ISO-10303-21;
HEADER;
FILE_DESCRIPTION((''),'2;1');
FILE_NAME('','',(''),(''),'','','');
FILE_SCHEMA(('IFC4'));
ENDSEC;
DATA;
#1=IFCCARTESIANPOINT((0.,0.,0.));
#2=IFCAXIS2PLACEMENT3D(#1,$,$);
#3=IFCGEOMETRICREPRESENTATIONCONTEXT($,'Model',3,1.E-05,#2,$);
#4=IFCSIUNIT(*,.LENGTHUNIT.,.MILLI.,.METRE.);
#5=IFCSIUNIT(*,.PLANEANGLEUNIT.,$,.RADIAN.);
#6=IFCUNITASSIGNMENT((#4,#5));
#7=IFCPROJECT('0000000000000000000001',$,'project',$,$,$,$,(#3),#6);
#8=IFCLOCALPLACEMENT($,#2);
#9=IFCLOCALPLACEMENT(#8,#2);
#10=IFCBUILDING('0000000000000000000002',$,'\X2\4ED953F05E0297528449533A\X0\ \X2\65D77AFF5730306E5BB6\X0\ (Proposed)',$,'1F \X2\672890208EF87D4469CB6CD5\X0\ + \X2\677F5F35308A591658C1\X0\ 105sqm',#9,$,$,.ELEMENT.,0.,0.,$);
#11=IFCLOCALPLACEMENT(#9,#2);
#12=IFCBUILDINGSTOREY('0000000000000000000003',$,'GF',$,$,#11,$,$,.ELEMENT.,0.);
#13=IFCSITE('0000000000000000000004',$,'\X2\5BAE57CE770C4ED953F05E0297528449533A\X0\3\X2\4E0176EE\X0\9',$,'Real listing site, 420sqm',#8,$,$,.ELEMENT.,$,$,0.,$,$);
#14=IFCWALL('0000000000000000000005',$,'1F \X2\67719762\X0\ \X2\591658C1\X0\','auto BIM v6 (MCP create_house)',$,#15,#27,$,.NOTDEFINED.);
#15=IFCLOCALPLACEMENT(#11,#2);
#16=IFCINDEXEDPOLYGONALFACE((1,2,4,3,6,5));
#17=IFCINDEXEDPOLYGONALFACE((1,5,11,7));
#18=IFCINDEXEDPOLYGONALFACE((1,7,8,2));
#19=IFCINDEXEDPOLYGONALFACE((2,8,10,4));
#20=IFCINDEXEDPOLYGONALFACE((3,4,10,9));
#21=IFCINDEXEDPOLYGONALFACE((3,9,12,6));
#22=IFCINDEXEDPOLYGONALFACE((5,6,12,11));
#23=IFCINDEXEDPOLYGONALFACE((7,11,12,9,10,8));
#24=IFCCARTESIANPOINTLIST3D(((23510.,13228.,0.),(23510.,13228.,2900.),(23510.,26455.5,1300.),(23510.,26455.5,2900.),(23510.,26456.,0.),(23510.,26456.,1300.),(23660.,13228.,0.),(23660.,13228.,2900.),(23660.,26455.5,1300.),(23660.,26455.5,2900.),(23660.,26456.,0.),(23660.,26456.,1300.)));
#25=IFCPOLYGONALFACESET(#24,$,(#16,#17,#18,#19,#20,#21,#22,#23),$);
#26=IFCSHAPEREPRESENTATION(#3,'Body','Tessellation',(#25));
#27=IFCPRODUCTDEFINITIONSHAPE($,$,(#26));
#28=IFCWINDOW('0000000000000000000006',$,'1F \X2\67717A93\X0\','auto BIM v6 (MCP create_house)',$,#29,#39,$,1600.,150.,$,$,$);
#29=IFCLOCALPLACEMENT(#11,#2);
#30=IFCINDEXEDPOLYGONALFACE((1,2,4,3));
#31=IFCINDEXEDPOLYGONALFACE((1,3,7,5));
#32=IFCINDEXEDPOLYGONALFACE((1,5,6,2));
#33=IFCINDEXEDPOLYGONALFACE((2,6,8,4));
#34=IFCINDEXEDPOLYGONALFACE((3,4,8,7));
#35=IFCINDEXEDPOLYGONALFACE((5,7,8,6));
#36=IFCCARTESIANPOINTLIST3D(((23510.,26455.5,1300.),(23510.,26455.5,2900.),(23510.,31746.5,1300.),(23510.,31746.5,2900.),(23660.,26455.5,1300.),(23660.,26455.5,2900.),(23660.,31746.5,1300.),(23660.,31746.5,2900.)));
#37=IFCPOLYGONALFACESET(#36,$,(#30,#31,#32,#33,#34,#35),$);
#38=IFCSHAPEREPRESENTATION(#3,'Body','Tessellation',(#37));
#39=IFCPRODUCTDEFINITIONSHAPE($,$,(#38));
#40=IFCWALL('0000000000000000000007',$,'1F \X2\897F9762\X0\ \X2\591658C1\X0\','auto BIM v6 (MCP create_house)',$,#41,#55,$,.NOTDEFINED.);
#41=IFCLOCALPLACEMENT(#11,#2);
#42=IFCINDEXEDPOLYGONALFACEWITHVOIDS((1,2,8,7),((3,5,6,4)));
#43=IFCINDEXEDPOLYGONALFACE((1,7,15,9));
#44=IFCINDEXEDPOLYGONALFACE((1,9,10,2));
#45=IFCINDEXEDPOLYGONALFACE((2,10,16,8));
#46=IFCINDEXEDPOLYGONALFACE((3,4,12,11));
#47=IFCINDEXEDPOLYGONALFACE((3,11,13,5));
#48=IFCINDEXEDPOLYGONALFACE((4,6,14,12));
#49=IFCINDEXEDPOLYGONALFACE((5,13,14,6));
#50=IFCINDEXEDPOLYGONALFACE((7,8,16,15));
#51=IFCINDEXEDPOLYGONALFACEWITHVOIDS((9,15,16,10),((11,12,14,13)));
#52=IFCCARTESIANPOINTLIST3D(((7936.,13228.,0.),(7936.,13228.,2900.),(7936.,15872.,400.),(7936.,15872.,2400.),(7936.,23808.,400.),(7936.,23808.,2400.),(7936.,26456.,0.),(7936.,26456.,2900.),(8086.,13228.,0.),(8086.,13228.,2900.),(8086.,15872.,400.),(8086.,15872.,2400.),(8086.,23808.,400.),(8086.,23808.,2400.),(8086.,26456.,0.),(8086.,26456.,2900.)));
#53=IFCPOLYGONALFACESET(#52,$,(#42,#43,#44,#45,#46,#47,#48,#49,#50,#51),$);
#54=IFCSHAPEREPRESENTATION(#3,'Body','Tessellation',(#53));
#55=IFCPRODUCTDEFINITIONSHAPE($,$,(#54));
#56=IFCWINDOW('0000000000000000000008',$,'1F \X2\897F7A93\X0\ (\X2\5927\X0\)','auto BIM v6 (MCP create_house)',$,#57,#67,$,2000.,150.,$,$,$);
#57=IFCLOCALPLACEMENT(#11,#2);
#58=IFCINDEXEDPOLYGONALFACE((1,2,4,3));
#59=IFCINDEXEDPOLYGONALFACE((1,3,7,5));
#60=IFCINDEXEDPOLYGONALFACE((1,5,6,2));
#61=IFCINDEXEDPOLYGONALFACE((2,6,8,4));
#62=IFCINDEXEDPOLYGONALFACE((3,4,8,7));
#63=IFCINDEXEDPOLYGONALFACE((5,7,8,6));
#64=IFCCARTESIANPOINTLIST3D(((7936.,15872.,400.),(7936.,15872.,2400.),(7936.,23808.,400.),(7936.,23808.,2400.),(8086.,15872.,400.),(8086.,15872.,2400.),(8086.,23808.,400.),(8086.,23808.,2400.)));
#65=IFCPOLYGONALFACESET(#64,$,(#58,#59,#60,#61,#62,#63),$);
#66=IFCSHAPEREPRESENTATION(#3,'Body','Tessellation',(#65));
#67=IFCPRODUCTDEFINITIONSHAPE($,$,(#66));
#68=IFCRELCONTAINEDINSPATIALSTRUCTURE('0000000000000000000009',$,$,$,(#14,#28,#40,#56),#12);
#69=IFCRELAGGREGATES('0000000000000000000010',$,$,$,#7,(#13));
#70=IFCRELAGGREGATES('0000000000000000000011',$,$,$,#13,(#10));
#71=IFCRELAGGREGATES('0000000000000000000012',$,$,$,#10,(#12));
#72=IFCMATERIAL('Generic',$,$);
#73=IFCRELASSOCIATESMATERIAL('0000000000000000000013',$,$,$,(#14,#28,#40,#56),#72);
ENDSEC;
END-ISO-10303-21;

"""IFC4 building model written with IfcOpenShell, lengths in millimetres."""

from ifc_helpers import new_model, si_unit, frame, frame_2d, origin, place, context, project, spatial, rectangle, extrude, material, element, fill, save


model = new_model("IFC4")

# Units and contexts
model_context = context("Model", 3, precision=1e-05, world=origin())
ifc_project = project(units=[si_unit("LENGTHUNIT", "METRE", prefix="MILLI"), si_unit("PLANEANGLEUNIT", "RADIAN")], contexts=[model_context])

# Site, building, storey
site_placement = place(None, origin())
site = spatial("IfcSite", under=ifc_project, at=site_placement, Name="宮城県仙台市青葉区3丁目9", ObjectType="Real listing site, 420sqm", CompositionType="ELEMENT", RefElevation=0.0)
building_placement = place(site_placement, origin())
building = spatial("IfcBuilding", under=site, at=building_placement, Name="仙台市青葉区 旗竿地の家 (Proposed)", ObjectType="1F 木造軸組構法 + 板張り外壁 105sqm", CompositionType="ELEMENT", ElevationOfRefHeight=0.0, ElevationOfTerrain=0.0)
storey_placement = place(building_placement, origin())
storey = spatial("IfcBuildingStorey", under=building, at=storey_placement, Name="GF", CompositionType="ELEMENT", Elevation=0.0)

# Shared definitions
ifc_material = material(Name="Generic")

# Walls, openings, windows
wall_1_placement = place(storey_placement, frame((11755.0, 6614.0, 0.0)))
wall_1 = element("IfcWall", 1, at=wall_1_placement, inside=storey, material=ifc_material, Name="1F 東面 外壁", Description="auto BIM v6 (MCP create_house)", PredefinedType="NOTDEFINED", context=model_context, shape_type="SweptSolid", body=[
    extrude(rectangle(XDim=150.0, YDim=13228.0, at=frame_2d((75.0, 6614.0))), frame((11755.0, 6614.0, 0.0)), (0.0, 0.0, 1.0), 2900.0),
])
opening_1_placement = place(storey_placement, frame((11755.0, 13228.0, 650.0)))
opening_1 = element("IfcOpeningElement", 2, at=opening_1_placement, cuts=wall_1, PredefinedType="NOTDEFINED", context=model_context, shape_type="SweptSolid", body=[
    extrude(rectangle(XDim=150.0, YDim=5291.0, at=frame_2d((75.0, 2645.0))), frame((11755.0, 13228.0, 650.0)), (0.0, 0.0, 1.0), 1600.0),
])
window_1_placement = place(storey_placement, frame((11755.0, 13228.0, 650.0)))
window_1 = element("IfcWindow", 3, at=window_1_placement, inside=storey, material=ifc_material, Name="1F 東窓", Description="auto BIM v6 (MCP create_house)", OverallHeight=1600.0, OverallWidth=150.0, context=model_context, shape_type="SweptSolid", body=[
    extrude(rectangle(XDim=150.0, YDim=5291.0, at=frame_2d((75.0, 2645.0))), frame((11755.0, 13228.0, 650.0)), (0.0, 0.0, 1.0), 1600.0),
])
fill(opening_1, window_1)
wall_2_placement = place(storey_placement, frame((3968.0, 6614.0, 0.0)))
wall_2 = element("IfcWall", 4, at=wall_2_placement, inside=storey, material=ifc_material, Name="1F 西面 外壁", Description="auto BIM v6 (MCP create_house)", PredefinedType="NOTDEFINED", context=model_context, shape_type="SweptSolid", body=[
    extrude(rectangle(XDim=150.0, YDim=13228.0, at=frame_2d((75.0, 6614.0))), frame((3968.0, 6614.0, 0.0)), (0.0, 0.0, 1.0), 2900.0),
])
opening_2_placement = place(storey_placement, frame((3968.0, 7936.0, 200.0)))
opening_2 = element("IfcOpeningElement", 5, at=opening_2_placement, cuts=wall_2, PredefinedType="NOTDEFINED", context=model_context, shape_type="SweptSolid", body=[
    extrude(rectangle(XDim=150.0, YDim=7936.0, at=frame_2d((75.0, 3968.0))), frame((3968.0, 7936.0, 200.0)), (0.0, 0.0, 1.0), 2000.0),
])
window_2_placement = place(storey_placement, frame((3968.0, 7936.0, 200.0)))
window_2 = element("IfcWindow", 6, at=window_2_placement, inside=storey, material=ifc_material, Name="1F 西窓 (大)", Description="auto BIM v6 (MCP create_house)", OverallHeight=2000.0, OverallWidth=150.0, context=model_context, shape_type="SweptSolid", body=[
    extrude(rectangle(XDim=150.0, YDim=7936.0, at=frame_2d((75.0, 3968.0))), frame((3968.0, 7936.0, 200.0)), (0.0, 0.0, 1.0), 2000.0),
])
fill(opening_2, window_2)

save(model, "model.ifc")
